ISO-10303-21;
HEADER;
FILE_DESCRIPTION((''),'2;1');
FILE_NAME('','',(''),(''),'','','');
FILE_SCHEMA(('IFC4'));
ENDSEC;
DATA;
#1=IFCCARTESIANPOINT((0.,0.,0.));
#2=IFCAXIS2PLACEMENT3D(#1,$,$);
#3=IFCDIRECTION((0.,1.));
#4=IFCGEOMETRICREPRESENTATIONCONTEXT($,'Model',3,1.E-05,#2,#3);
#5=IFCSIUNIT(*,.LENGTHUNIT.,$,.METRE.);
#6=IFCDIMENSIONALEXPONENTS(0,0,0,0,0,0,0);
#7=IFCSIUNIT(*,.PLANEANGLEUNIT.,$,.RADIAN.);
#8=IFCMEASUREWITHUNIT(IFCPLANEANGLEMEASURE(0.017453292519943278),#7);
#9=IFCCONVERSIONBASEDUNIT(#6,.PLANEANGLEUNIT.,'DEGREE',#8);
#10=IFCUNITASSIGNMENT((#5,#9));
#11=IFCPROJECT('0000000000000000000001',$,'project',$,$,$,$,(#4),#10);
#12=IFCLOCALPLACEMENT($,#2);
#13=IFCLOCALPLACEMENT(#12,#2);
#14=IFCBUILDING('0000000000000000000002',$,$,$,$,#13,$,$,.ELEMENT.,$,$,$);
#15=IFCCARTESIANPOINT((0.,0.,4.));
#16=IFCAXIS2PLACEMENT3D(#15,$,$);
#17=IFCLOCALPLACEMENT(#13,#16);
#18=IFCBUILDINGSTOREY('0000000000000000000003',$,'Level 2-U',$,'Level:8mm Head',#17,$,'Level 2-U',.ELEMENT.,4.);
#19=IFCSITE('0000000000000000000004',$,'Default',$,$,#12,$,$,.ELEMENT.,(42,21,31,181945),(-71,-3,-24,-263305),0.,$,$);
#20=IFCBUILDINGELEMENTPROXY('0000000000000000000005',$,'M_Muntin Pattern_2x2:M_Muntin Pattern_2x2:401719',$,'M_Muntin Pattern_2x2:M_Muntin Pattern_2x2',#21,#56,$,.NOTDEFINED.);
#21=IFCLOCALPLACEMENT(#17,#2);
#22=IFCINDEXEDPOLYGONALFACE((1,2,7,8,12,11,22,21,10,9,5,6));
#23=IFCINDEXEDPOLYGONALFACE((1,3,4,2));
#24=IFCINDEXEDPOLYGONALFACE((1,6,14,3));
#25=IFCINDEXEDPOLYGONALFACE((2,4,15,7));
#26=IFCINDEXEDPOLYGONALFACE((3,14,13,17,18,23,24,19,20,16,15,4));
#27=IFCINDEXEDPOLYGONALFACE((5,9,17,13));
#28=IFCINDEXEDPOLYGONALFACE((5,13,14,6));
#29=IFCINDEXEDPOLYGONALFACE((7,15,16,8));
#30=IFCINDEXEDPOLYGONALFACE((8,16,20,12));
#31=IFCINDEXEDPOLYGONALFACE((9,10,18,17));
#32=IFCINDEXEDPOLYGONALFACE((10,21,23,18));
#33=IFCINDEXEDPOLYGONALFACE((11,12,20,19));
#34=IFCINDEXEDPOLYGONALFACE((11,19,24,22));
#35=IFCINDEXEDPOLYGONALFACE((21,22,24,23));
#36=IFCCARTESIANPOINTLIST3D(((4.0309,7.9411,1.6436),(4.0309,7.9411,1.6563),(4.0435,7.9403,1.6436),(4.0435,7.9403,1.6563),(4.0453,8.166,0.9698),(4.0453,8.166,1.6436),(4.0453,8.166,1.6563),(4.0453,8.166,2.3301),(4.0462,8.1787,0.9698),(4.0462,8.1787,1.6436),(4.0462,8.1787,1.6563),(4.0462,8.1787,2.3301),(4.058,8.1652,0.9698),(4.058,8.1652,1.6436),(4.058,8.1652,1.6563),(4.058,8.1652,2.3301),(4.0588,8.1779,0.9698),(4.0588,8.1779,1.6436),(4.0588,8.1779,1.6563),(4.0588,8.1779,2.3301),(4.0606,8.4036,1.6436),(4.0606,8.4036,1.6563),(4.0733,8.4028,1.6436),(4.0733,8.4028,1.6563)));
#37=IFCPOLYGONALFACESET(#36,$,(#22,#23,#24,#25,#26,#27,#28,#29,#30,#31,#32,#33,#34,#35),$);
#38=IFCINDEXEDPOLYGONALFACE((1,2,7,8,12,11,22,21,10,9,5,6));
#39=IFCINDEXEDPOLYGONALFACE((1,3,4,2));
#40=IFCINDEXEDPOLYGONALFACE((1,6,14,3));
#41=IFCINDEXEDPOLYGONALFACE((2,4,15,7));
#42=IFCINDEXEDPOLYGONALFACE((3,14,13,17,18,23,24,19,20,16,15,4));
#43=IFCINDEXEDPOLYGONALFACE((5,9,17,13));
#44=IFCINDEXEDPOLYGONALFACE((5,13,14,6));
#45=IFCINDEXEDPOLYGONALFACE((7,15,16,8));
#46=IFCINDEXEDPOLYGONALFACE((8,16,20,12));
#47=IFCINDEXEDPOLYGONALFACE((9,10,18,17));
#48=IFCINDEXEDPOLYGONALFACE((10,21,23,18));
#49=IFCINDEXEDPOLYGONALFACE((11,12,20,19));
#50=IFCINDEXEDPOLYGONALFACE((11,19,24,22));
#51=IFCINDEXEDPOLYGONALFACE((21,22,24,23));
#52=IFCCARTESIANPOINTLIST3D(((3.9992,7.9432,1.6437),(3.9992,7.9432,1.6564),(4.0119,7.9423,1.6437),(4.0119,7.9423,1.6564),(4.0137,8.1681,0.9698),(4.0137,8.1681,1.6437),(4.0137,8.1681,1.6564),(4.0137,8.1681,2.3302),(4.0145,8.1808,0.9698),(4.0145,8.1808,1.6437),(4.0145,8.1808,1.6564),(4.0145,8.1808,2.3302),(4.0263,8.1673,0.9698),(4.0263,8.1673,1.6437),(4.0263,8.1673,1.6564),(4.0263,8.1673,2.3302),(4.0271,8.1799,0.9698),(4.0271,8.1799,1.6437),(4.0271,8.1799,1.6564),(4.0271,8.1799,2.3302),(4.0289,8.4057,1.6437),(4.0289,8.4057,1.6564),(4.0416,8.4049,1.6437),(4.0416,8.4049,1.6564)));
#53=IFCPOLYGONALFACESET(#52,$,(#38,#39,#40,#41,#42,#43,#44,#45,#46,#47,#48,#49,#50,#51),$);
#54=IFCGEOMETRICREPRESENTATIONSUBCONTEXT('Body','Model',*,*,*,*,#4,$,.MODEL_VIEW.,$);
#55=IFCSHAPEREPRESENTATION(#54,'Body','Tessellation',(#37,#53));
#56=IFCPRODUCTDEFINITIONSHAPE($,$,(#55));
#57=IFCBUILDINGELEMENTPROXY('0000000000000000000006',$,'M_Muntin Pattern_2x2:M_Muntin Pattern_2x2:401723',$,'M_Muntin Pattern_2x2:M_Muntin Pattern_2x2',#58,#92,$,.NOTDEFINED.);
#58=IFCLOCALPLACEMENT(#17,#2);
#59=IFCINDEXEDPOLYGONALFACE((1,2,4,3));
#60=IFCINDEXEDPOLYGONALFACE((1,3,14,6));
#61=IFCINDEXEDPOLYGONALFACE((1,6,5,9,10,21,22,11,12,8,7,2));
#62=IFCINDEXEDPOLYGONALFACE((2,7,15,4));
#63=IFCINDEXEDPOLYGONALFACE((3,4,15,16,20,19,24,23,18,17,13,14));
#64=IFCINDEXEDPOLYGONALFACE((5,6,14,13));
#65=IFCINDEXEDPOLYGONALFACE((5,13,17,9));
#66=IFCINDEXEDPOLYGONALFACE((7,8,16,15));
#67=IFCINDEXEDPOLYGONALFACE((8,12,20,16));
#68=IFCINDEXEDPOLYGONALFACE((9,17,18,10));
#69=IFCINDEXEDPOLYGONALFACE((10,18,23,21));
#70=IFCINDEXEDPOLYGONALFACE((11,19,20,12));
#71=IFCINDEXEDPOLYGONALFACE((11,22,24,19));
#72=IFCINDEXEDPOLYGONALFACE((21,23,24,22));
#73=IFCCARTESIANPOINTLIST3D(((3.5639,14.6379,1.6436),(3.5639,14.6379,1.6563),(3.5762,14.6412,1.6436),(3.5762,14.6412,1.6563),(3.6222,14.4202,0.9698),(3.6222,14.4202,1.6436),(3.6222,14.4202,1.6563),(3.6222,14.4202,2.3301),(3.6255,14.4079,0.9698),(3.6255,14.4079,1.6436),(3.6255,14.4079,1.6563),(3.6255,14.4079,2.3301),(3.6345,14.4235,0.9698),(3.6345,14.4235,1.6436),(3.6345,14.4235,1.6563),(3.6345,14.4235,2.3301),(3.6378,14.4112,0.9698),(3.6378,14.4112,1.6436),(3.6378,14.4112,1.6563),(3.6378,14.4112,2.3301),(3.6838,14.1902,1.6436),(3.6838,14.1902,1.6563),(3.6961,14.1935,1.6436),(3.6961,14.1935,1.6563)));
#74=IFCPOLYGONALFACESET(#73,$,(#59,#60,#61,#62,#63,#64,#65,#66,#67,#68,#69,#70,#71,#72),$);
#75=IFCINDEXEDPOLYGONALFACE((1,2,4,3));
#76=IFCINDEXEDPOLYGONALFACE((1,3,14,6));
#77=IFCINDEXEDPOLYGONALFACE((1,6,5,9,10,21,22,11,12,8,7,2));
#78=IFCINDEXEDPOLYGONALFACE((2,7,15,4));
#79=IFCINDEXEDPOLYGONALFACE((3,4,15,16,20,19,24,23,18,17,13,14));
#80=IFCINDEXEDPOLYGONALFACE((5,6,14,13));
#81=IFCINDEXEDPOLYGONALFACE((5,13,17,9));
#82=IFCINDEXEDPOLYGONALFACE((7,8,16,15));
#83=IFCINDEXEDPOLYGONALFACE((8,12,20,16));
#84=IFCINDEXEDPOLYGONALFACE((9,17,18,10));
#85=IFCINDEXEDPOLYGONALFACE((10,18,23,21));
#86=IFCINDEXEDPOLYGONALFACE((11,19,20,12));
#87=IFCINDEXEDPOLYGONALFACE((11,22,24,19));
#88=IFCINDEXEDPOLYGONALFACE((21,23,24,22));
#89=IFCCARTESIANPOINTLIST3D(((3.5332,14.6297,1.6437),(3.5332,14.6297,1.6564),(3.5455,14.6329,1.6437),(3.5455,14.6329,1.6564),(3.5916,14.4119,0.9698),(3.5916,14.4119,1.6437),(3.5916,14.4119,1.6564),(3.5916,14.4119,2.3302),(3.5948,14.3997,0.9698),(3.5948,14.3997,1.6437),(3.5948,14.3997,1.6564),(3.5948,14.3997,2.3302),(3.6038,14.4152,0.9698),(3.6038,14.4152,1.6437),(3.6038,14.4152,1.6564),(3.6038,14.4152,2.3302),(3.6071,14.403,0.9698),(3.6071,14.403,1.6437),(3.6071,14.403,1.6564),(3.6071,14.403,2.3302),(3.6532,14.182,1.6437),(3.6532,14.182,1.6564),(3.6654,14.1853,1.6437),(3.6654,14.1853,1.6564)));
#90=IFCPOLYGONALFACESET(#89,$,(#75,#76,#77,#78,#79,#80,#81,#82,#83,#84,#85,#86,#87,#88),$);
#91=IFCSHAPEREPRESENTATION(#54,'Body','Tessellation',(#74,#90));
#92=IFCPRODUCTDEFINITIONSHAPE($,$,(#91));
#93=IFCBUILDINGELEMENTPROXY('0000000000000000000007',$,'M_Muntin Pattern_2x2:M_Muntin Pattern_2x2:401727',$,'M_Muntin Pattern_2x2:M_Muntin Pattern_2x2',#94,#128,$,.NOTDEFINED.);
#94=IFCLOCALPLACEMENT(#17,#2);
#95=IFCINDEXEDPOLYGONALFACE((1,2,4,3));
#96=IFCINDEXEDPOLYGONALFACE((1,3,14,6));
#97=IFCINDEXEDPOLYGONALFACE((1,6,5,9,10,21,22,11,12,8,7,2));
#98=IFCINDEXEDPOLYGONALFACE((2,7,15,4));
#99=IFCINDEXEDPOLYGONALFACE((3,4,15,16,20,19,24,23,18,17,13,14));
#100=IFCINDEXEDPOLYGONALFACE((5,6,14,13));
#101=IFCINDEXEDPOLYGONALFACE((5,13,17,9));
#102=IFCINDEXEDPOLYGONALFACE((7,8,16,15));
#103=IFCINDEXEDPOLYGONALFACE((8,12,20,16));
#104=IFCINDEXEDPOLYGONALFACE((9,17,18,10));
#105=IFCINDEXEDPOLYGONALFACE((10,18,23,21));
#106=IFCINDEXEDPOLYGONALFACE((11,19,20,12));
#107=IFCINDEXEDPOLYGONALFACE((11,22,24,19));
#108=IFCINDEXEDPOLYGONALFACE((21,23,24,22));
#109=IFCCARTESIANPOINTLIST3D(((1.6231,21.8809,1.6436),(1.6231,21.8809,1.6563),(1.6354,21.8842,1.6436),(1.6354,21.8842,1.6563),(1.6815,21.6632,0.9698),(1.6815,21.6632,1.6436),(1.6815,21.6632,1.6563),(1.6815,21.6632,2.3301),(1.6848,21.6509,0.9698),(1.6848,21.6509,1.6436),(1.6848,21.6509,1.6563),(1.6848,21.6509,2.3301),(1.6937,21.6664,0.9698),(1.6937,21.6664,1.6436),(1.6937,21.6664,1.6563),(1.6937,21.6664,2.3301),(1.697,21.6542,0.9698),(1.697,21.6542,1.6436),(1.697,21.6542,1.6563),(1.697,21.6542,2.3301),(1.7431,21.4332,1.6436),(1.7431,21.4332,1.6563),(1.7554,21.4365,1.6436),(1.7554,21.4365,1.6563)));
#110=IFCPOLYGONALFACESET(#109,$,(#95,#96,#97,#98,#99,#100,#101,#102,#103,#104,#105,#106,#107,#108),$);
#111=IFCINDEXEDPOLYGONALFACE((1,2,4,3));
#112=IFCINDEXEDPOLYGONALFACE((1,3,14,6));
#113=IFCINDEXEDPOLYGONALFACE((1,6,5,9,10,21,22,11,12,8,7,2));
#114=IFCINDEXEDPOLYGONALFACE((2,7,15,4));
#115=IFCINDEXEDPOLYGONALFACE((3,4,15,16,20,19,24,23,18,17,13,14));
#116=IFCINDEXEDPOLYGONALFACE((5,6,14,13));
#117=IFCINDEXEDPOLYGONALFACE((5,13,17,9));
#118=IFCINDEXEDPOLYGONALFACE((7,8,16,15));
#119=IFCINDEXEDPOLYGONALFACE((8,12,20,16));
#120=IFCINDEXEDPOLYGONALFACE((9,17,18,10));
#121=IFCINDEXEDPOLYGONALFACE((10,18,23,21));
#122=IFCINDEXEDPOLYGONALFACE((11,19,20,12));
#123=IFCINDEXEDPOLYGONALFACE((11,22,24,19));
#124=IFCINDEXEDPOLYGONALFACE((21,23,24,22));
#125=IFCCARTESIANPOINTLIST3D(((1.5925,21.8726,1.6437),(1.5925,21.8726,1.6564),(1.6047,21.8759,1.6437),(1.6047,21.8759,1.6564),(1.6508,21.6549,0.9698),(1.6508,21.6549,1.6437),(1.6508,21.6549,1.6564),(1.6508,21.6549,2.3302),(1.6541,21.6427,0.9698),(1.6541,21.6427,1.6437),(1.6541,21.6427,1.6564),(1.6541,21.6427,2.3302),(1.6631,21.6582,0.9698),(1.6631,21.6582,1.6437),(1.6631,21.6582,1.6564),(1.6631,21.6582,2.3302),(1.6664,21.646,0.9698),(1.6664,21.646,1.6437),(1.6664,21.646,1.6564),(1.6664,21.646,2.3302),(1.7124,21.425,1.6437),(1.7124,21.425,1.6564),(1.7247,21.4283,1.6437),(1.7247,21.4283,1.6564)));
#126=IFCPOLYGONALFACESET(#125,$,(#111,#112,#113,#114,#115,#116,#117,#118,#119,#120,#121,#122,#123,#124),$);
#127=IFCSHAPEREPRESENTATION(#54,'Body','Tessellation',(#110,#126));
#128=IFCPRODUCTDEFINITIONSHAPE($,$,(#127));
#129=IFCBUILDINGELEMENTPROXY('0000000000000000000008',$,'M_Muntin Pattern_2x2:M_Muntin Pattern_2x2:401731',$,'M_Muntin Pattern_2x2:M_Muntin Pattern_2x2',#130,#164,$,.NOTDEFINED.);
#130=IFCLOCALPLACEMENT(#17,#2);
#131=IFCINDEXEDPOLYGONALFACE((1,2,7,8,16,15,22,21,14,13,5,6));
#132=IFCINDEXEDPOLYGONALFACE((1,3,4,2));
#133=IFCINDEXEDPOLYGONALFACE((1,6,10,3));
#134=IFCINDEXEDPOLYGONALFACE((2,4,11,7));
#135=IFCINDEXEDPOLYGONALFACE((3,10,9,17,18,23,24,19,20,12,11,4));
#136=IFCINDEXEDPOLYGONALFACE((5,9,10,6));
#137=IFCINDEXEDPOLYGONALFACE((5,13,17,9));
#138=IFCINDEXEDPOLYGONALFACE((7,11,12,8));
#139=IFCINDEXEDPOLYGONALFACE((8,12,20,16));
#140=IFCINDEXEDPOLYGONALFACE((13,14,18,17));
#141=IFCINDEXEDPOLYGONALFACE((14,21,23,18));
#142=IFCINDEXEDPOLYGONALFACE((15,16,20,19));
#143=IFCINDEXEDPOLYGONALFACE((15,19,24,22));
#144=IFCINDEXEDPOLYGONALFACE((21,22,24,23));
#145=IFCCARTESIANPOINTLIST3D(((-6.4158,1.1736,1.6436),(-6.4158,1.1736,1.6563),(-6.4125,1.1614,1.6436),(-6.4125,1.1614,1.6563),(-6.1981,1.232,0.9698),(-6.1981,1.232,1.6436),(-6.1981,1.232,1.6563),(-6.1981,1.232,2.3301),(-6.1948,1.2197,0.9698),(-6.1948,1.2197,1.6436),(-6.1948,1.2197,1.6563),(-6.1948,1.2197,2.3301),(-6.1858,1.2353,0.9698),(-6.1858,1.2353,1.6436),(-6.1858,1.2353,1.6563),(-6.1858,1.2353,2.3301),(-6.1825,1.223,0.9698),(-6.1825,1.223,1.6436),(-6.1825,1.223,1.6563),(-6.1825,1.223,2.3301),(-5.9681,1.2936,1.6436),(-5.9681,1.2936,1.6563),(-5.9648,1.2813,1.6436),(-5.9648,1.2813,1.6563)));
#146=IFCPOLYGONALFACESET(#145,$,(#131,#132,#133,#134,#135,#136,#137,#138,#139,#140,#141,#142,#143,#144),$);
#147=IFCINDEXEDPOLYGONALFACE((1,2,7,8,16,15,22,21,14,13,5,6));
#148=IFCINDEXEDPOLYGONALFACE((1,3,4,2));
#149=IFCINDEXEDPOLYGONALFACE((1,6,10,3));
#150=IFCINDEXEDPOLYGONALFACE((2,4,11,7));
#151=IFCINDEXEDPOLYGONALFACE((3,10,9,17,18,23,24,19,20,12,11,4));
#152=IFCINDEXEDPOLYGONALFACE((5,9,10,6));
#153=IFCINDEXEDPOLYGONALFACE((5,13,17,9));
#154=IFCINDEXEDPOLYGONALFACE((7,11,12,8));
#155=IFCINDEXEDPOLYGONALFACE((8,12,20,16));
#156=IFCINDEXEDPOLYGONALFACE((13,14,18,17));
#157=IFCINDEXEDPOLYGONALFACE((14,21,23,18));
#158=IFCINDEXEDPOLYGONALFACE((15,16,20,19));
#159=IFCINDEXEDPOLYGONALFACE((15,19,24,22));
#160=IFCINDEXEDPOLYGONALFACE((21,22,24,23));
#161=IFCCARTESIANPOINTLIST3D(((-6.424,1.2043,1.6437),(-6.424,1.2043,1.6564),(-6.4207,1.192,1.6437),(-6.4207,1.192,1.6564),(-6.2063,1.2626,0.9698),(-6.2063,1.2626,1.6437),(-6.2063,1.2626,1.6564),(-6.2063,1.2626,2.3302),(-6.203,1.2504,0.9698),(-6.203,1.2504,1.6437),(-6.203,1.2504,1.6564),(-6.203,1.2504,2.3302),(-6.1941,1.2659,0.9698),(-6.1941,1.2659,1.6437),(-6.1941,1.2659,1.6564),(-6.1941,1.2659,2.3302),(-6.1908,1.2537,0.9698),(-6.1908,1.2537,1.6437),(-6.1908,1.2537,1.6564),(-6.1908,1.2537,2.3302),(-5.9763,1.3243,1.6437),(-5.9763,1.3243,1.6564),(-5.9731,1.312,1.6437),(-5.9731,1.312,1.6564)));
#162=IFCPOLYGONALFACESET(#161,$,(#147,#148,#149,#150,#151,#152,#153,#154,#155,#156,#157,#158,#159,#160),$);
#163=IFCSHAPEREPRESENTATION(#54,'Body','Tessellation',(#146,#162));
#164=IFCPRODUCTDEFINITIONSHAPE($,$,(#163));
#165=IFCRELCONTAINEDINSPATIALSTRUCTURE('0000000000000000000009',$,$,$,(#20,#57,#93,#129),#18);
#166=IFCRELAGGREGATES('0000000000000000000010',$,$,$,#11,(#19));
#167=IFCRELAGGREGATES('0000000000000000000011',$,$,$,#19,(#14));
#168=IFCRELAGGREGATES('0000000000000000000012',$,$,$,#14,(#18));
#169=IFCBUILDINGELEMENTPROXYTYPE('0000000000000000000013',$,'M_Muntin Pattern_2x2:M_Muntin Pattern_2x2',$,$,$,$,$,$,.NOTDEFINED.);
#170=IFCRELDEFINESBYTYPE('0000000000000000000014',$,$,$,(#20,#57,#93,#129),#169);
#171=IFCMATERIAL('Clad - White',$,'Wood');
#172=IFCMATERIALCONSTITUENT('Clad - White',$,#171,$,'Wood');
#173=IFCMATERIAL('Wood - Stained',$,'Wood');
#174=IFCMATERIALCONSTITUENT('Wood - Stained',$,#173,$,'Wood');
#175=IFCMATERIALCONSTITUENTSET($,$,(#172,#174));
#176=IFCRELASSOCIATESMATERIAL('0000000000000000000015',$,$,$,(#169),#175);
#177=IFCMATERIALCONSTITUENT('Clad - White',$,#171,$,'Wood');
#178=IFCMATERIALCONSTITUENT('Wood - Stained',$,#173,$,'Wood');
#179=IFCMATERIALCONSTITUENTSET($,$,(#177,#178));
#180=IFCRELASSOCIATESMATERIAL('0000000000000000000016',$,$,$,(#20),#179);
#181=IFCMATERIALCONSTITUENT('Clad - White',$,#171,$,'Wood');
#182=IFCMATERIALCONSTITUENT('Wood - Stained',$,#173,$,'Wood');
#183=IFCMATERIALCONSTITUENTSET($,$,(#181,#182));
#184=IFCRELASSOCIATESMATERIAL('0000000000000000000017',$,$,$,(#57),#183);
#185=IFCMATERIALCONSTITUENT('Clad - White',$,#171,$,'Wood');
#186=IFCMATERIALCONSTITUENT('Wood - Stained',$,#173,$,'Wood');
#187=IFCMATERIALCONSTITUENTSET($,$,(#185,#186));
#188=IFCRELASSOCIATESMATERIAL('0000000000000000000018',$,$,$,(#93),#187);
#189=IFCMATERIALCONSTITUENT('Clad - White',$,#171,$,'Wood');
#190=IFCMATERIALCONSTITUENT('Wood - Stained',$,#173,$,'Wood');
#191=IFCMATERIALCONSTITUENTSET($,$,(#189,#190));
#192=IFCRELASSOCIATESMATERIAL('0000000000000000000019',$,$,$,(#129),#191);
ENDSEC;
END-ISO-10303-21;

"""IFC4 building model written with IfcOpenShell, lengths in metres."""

from ifc_helpers import new_model, entity, si_unit, converted_unit, direction, frame, origin, place, context, subcontext, project, spatial, polyline, outline, extrude, source, transform, mapped, material, constituent, constituent_set, type_object, type_shapes, element, save


model = new_model("IFC4")

# Units and contexts
model_context = context("Model", 3, precision=1e-05, world=origin(), true_north=direction((0.0, 1.0)))
body_context = subcontext(model_context, "Body", "Model", "MODEL_VIEW")
ifc_project = project(units=[si_unit("LENGTHUNIT", "METRE"), converted_unit("PLANEANGLEUNIT", "DEGREE", entity("IfcPlaneAngleMeasure", 0.017453292519943278), si_unit("PLANEANGLEUNIT", "RADIAN"), dimensions=[0, 0, 0, 0, 0, 0, 0])], contexts=[model_context])

# Site, building, storey
site_placement = place(None, origin())
site = spatial("IfcSite", under=ifc_project, at=site_placement, Name="Default", CompositionType="ELEMENT", RefLatitude=(42, 21, 31, 181945), RefLongitude=(-71, -3, -24, -263305), RefElevation=0.0)
building_placement = place(site_placement, origin())
building = spatial("IfcBuilding", under=site, at=building_placement, CompositionType="ELEMENT")
storey_placement = place(building_placement, frame((0.0, 0.0, 4.0)))
storey = spatial("IfcBuildingStorey", under=building, at=storey_placement, Name="Level 2-U", ObjectType="Level:8mm Head", LongName="Level 2-U", CompositionType="ELEMENT", Elevation=4.0)

# Building element proxies
ifc_material_1 = material(Name="Clad - White", Category="Wood")
ifc_constituent_1 = constituent(ifc_material_1, Name="Clad - White", Category="Wood")
ifc_material_2 = material(Name="Wood - Stained", Category="Wood")
ifc_constituent_2 = constituent(ifc_material_2, Name="Wood - Stained", Category="Wood")
ifc_constituent_set_1 = constituent_set(constituents=[ifc_constituent_1, ifc_constituent_2])
ifc_constituent_3 = constituent(ifc_material_1, Name="Clad - White", Category="Wood")
ifc_constituent_4 = constituent(ifc_material_2, Name="Wood - Stained", Category="Wood")
ifc_constituent_set_2 = constituent_set(constituents=[ifc_constituent_3, ifc_constituent_4])
building_element_proxy_type_1 = type_object("IfcBuildingElementProxyType", Name="M_Muntin Pattern_2x2:M_Muntin Pattern_2x2", PredefinedType="NOTDEFINED", material=ifc_constituent_set_2)
shared_shape_1 = source(origin(), body_context, "Body", "SweptSolid", [
    extrude(outline(polyline([(0.0064, -0.0064), (0.6801, -0.0064), (0.6801, 0.0063), (0.0064, 0.0063), (0.0064, 0.2317), (-0.0063, 0.2317), (-0.0063, 0.0063), (-0.6802, 0.0063), (-0.6802, -0.0064), (-0.0063, -0.0064), (-0.0063, -0.2317), (0.0064, -0.2317), (0.0064, -0.0064)])), frame((0.0, 0.0095, 0.6801), z_axis=(0.0, 1.0, 0.0), x_axis=(0.0, 0.0, 1.0)), (0.0, 0.0, 1.0), 0.0127),
    extrude(outline(polyline([(0.0064, -0.0064), (0.6802, -0.0064), (0.6802, 0.0063), (0.0064, 0.0063), (0.0064, 0.2317), (-0.0063, 0.2317), (-0.0063, 0.0063), (-0.6802, 0.0063), (-0.6802, -0.0064), (-0.0063, -0.0064), (-0.0063, -0.2317), (0.0064, -0.2317), (0.0064, -0.0064)])), frame((0.0, -0.0222, 0.6802), z_axis=(0.0, 1.0, 0.0), x_axis=(0.0, 0.0, 1.0)), (0.0, 0.0, 1.0), 0.0127),
])
type_shapes(building_element_proxy_type_1, [shared_shape_1])
proxy_1_placement = place(storey_placement, frame((4.0362, 8.173, 0.9698), z_axis=(0.0, 0.0, 1.0), x_axis=(-0.064186, -0.997938, 0.0)))
element("IfcBuildingElementProxy", 1, at=proxy_1_placement, inside=storey, type_object=building_element_proxy_type_1, material=ifc_constituent_set_1, Name="M_Muntin Pattern_2x2:M_Muntin Pattern_2x2:401719", ObjectType="M_Muntin Pattern_2x2:M_Muntin Pattern_2x2", PredefinedType="NOTDEFINED", context=body_context, shape_type="MappedRepresentation", body=[
    mapped(shared_shape_1, transform((0.0, 0.0, 0.0), scale=1.0)),
])
ifc_constituent_5 = constituent(ifc_material_1, Name="Clad - White", Category="Wood")
ifc_constituent_6 = constituent(ifc_material_2, Name="Wood - Stained", Category="Wood")
ifc_constituent_set_3 = constituent_set(constituents=[ifc_constituent_5, ifc_constituent_6])
proxy_2_placement = place(storey_placement, frame((3.6147, 14.4116, 0.9698), z_axis=(0.0, 0.0, 1.0), x_axis=(0.258819, -0.965926, 0.0)))
element("IfcBuildingElementProxy", 2, at=proxy_2_placement, inside=storey, type_object=building_element_proxy_type_1, material=ifc_constituent_set_3, Name="M_Muntin Pattern_2x2:M_Muntin Pattern_2x2:401723", ObjectType="M_Muntin Pattern_2x2:M_Muntin Pattern_2x2", PredefinedType="NOTDEFINED", context=body_context, shape_type="MappedRepresentation", body=[
    mapped(shared_shape_1, transform((0.0, 0.0, 0.0), scale=1.0)),
])
ifc_constituent_7 = constituent(ifc_material_1, Name="Clad - White", Category="Wood")
ifc_constituent_8 = constituent(ifc_material_2, Name="Wood - Stained", Category="Wood")
ifc_constituent_set_4 = constituent_set(constituents=[ifc_constituent_7, ifc_constituent_8])
proxy_3_placement = place(storey_placement, frame((1.6739, 21.6546, 0.9698), z_axis=(0.0, 0.0, 1.0), x_axis=(0.258819, -0.965926, 0.0)))
element("IfcBuildingElementProxy", 3, at=proxy_3_placement, inside=storey, type_object=building_element_proxy_type_1, material=ifc_constituent_set_4, Name="M_Muntin Pattern_2x2:M_Muntin Pattern_2x2:401727", ObjectType="M_Muntin Pattern_2x2:M_Muntin Pattern_2x2", PredefinedType="NOTDEFINED", context=body_context, shape_type="MappedRepresentation", body=[
    mapped(shared_shape_1, transform((0.0, 0.0, 0.0), scale=1.0)),
])
ifc_constituent_9 = constituent(ifc_material_1, Name="Clad - White", Category="Wood")
ifc_constituent_10 = constituent(ifc_material_2, Name="Wood - Stained", Category="Wood")
ifc_constituent_set_5 = constituent_set(constituents=[ifc_constituent_9, ifc_constituent_10])
proxy_4_placement = place(storey_placement, frame((-6.1944, 1.2428, 0.9698), z_axis=(0.0, 0.0, 1.0), x_axis=(-0.965926, -0.258819, 0.0)))
element("IfcBuildingElementProxy", 4, at=proxy_4_placement, inside=storey, type_object=building_element_proxy_type_1, material=ifc_constituent_set_5, Name="M_Muntin Pattern_2x2:M_Muntin Pattern_2x2:401731", ObjectType="M_Muntin Pattern_2x2:M_Muntin Pattern_2x2", PredefinedType="NOTDEFINED", context=body_context, shape_type="MappedRepresentation", body=[
    mapped(shared_shape_1, transform((0.0, 0.0, 0.0), scale=1.0)),
])

save(model, "model.ifc")
